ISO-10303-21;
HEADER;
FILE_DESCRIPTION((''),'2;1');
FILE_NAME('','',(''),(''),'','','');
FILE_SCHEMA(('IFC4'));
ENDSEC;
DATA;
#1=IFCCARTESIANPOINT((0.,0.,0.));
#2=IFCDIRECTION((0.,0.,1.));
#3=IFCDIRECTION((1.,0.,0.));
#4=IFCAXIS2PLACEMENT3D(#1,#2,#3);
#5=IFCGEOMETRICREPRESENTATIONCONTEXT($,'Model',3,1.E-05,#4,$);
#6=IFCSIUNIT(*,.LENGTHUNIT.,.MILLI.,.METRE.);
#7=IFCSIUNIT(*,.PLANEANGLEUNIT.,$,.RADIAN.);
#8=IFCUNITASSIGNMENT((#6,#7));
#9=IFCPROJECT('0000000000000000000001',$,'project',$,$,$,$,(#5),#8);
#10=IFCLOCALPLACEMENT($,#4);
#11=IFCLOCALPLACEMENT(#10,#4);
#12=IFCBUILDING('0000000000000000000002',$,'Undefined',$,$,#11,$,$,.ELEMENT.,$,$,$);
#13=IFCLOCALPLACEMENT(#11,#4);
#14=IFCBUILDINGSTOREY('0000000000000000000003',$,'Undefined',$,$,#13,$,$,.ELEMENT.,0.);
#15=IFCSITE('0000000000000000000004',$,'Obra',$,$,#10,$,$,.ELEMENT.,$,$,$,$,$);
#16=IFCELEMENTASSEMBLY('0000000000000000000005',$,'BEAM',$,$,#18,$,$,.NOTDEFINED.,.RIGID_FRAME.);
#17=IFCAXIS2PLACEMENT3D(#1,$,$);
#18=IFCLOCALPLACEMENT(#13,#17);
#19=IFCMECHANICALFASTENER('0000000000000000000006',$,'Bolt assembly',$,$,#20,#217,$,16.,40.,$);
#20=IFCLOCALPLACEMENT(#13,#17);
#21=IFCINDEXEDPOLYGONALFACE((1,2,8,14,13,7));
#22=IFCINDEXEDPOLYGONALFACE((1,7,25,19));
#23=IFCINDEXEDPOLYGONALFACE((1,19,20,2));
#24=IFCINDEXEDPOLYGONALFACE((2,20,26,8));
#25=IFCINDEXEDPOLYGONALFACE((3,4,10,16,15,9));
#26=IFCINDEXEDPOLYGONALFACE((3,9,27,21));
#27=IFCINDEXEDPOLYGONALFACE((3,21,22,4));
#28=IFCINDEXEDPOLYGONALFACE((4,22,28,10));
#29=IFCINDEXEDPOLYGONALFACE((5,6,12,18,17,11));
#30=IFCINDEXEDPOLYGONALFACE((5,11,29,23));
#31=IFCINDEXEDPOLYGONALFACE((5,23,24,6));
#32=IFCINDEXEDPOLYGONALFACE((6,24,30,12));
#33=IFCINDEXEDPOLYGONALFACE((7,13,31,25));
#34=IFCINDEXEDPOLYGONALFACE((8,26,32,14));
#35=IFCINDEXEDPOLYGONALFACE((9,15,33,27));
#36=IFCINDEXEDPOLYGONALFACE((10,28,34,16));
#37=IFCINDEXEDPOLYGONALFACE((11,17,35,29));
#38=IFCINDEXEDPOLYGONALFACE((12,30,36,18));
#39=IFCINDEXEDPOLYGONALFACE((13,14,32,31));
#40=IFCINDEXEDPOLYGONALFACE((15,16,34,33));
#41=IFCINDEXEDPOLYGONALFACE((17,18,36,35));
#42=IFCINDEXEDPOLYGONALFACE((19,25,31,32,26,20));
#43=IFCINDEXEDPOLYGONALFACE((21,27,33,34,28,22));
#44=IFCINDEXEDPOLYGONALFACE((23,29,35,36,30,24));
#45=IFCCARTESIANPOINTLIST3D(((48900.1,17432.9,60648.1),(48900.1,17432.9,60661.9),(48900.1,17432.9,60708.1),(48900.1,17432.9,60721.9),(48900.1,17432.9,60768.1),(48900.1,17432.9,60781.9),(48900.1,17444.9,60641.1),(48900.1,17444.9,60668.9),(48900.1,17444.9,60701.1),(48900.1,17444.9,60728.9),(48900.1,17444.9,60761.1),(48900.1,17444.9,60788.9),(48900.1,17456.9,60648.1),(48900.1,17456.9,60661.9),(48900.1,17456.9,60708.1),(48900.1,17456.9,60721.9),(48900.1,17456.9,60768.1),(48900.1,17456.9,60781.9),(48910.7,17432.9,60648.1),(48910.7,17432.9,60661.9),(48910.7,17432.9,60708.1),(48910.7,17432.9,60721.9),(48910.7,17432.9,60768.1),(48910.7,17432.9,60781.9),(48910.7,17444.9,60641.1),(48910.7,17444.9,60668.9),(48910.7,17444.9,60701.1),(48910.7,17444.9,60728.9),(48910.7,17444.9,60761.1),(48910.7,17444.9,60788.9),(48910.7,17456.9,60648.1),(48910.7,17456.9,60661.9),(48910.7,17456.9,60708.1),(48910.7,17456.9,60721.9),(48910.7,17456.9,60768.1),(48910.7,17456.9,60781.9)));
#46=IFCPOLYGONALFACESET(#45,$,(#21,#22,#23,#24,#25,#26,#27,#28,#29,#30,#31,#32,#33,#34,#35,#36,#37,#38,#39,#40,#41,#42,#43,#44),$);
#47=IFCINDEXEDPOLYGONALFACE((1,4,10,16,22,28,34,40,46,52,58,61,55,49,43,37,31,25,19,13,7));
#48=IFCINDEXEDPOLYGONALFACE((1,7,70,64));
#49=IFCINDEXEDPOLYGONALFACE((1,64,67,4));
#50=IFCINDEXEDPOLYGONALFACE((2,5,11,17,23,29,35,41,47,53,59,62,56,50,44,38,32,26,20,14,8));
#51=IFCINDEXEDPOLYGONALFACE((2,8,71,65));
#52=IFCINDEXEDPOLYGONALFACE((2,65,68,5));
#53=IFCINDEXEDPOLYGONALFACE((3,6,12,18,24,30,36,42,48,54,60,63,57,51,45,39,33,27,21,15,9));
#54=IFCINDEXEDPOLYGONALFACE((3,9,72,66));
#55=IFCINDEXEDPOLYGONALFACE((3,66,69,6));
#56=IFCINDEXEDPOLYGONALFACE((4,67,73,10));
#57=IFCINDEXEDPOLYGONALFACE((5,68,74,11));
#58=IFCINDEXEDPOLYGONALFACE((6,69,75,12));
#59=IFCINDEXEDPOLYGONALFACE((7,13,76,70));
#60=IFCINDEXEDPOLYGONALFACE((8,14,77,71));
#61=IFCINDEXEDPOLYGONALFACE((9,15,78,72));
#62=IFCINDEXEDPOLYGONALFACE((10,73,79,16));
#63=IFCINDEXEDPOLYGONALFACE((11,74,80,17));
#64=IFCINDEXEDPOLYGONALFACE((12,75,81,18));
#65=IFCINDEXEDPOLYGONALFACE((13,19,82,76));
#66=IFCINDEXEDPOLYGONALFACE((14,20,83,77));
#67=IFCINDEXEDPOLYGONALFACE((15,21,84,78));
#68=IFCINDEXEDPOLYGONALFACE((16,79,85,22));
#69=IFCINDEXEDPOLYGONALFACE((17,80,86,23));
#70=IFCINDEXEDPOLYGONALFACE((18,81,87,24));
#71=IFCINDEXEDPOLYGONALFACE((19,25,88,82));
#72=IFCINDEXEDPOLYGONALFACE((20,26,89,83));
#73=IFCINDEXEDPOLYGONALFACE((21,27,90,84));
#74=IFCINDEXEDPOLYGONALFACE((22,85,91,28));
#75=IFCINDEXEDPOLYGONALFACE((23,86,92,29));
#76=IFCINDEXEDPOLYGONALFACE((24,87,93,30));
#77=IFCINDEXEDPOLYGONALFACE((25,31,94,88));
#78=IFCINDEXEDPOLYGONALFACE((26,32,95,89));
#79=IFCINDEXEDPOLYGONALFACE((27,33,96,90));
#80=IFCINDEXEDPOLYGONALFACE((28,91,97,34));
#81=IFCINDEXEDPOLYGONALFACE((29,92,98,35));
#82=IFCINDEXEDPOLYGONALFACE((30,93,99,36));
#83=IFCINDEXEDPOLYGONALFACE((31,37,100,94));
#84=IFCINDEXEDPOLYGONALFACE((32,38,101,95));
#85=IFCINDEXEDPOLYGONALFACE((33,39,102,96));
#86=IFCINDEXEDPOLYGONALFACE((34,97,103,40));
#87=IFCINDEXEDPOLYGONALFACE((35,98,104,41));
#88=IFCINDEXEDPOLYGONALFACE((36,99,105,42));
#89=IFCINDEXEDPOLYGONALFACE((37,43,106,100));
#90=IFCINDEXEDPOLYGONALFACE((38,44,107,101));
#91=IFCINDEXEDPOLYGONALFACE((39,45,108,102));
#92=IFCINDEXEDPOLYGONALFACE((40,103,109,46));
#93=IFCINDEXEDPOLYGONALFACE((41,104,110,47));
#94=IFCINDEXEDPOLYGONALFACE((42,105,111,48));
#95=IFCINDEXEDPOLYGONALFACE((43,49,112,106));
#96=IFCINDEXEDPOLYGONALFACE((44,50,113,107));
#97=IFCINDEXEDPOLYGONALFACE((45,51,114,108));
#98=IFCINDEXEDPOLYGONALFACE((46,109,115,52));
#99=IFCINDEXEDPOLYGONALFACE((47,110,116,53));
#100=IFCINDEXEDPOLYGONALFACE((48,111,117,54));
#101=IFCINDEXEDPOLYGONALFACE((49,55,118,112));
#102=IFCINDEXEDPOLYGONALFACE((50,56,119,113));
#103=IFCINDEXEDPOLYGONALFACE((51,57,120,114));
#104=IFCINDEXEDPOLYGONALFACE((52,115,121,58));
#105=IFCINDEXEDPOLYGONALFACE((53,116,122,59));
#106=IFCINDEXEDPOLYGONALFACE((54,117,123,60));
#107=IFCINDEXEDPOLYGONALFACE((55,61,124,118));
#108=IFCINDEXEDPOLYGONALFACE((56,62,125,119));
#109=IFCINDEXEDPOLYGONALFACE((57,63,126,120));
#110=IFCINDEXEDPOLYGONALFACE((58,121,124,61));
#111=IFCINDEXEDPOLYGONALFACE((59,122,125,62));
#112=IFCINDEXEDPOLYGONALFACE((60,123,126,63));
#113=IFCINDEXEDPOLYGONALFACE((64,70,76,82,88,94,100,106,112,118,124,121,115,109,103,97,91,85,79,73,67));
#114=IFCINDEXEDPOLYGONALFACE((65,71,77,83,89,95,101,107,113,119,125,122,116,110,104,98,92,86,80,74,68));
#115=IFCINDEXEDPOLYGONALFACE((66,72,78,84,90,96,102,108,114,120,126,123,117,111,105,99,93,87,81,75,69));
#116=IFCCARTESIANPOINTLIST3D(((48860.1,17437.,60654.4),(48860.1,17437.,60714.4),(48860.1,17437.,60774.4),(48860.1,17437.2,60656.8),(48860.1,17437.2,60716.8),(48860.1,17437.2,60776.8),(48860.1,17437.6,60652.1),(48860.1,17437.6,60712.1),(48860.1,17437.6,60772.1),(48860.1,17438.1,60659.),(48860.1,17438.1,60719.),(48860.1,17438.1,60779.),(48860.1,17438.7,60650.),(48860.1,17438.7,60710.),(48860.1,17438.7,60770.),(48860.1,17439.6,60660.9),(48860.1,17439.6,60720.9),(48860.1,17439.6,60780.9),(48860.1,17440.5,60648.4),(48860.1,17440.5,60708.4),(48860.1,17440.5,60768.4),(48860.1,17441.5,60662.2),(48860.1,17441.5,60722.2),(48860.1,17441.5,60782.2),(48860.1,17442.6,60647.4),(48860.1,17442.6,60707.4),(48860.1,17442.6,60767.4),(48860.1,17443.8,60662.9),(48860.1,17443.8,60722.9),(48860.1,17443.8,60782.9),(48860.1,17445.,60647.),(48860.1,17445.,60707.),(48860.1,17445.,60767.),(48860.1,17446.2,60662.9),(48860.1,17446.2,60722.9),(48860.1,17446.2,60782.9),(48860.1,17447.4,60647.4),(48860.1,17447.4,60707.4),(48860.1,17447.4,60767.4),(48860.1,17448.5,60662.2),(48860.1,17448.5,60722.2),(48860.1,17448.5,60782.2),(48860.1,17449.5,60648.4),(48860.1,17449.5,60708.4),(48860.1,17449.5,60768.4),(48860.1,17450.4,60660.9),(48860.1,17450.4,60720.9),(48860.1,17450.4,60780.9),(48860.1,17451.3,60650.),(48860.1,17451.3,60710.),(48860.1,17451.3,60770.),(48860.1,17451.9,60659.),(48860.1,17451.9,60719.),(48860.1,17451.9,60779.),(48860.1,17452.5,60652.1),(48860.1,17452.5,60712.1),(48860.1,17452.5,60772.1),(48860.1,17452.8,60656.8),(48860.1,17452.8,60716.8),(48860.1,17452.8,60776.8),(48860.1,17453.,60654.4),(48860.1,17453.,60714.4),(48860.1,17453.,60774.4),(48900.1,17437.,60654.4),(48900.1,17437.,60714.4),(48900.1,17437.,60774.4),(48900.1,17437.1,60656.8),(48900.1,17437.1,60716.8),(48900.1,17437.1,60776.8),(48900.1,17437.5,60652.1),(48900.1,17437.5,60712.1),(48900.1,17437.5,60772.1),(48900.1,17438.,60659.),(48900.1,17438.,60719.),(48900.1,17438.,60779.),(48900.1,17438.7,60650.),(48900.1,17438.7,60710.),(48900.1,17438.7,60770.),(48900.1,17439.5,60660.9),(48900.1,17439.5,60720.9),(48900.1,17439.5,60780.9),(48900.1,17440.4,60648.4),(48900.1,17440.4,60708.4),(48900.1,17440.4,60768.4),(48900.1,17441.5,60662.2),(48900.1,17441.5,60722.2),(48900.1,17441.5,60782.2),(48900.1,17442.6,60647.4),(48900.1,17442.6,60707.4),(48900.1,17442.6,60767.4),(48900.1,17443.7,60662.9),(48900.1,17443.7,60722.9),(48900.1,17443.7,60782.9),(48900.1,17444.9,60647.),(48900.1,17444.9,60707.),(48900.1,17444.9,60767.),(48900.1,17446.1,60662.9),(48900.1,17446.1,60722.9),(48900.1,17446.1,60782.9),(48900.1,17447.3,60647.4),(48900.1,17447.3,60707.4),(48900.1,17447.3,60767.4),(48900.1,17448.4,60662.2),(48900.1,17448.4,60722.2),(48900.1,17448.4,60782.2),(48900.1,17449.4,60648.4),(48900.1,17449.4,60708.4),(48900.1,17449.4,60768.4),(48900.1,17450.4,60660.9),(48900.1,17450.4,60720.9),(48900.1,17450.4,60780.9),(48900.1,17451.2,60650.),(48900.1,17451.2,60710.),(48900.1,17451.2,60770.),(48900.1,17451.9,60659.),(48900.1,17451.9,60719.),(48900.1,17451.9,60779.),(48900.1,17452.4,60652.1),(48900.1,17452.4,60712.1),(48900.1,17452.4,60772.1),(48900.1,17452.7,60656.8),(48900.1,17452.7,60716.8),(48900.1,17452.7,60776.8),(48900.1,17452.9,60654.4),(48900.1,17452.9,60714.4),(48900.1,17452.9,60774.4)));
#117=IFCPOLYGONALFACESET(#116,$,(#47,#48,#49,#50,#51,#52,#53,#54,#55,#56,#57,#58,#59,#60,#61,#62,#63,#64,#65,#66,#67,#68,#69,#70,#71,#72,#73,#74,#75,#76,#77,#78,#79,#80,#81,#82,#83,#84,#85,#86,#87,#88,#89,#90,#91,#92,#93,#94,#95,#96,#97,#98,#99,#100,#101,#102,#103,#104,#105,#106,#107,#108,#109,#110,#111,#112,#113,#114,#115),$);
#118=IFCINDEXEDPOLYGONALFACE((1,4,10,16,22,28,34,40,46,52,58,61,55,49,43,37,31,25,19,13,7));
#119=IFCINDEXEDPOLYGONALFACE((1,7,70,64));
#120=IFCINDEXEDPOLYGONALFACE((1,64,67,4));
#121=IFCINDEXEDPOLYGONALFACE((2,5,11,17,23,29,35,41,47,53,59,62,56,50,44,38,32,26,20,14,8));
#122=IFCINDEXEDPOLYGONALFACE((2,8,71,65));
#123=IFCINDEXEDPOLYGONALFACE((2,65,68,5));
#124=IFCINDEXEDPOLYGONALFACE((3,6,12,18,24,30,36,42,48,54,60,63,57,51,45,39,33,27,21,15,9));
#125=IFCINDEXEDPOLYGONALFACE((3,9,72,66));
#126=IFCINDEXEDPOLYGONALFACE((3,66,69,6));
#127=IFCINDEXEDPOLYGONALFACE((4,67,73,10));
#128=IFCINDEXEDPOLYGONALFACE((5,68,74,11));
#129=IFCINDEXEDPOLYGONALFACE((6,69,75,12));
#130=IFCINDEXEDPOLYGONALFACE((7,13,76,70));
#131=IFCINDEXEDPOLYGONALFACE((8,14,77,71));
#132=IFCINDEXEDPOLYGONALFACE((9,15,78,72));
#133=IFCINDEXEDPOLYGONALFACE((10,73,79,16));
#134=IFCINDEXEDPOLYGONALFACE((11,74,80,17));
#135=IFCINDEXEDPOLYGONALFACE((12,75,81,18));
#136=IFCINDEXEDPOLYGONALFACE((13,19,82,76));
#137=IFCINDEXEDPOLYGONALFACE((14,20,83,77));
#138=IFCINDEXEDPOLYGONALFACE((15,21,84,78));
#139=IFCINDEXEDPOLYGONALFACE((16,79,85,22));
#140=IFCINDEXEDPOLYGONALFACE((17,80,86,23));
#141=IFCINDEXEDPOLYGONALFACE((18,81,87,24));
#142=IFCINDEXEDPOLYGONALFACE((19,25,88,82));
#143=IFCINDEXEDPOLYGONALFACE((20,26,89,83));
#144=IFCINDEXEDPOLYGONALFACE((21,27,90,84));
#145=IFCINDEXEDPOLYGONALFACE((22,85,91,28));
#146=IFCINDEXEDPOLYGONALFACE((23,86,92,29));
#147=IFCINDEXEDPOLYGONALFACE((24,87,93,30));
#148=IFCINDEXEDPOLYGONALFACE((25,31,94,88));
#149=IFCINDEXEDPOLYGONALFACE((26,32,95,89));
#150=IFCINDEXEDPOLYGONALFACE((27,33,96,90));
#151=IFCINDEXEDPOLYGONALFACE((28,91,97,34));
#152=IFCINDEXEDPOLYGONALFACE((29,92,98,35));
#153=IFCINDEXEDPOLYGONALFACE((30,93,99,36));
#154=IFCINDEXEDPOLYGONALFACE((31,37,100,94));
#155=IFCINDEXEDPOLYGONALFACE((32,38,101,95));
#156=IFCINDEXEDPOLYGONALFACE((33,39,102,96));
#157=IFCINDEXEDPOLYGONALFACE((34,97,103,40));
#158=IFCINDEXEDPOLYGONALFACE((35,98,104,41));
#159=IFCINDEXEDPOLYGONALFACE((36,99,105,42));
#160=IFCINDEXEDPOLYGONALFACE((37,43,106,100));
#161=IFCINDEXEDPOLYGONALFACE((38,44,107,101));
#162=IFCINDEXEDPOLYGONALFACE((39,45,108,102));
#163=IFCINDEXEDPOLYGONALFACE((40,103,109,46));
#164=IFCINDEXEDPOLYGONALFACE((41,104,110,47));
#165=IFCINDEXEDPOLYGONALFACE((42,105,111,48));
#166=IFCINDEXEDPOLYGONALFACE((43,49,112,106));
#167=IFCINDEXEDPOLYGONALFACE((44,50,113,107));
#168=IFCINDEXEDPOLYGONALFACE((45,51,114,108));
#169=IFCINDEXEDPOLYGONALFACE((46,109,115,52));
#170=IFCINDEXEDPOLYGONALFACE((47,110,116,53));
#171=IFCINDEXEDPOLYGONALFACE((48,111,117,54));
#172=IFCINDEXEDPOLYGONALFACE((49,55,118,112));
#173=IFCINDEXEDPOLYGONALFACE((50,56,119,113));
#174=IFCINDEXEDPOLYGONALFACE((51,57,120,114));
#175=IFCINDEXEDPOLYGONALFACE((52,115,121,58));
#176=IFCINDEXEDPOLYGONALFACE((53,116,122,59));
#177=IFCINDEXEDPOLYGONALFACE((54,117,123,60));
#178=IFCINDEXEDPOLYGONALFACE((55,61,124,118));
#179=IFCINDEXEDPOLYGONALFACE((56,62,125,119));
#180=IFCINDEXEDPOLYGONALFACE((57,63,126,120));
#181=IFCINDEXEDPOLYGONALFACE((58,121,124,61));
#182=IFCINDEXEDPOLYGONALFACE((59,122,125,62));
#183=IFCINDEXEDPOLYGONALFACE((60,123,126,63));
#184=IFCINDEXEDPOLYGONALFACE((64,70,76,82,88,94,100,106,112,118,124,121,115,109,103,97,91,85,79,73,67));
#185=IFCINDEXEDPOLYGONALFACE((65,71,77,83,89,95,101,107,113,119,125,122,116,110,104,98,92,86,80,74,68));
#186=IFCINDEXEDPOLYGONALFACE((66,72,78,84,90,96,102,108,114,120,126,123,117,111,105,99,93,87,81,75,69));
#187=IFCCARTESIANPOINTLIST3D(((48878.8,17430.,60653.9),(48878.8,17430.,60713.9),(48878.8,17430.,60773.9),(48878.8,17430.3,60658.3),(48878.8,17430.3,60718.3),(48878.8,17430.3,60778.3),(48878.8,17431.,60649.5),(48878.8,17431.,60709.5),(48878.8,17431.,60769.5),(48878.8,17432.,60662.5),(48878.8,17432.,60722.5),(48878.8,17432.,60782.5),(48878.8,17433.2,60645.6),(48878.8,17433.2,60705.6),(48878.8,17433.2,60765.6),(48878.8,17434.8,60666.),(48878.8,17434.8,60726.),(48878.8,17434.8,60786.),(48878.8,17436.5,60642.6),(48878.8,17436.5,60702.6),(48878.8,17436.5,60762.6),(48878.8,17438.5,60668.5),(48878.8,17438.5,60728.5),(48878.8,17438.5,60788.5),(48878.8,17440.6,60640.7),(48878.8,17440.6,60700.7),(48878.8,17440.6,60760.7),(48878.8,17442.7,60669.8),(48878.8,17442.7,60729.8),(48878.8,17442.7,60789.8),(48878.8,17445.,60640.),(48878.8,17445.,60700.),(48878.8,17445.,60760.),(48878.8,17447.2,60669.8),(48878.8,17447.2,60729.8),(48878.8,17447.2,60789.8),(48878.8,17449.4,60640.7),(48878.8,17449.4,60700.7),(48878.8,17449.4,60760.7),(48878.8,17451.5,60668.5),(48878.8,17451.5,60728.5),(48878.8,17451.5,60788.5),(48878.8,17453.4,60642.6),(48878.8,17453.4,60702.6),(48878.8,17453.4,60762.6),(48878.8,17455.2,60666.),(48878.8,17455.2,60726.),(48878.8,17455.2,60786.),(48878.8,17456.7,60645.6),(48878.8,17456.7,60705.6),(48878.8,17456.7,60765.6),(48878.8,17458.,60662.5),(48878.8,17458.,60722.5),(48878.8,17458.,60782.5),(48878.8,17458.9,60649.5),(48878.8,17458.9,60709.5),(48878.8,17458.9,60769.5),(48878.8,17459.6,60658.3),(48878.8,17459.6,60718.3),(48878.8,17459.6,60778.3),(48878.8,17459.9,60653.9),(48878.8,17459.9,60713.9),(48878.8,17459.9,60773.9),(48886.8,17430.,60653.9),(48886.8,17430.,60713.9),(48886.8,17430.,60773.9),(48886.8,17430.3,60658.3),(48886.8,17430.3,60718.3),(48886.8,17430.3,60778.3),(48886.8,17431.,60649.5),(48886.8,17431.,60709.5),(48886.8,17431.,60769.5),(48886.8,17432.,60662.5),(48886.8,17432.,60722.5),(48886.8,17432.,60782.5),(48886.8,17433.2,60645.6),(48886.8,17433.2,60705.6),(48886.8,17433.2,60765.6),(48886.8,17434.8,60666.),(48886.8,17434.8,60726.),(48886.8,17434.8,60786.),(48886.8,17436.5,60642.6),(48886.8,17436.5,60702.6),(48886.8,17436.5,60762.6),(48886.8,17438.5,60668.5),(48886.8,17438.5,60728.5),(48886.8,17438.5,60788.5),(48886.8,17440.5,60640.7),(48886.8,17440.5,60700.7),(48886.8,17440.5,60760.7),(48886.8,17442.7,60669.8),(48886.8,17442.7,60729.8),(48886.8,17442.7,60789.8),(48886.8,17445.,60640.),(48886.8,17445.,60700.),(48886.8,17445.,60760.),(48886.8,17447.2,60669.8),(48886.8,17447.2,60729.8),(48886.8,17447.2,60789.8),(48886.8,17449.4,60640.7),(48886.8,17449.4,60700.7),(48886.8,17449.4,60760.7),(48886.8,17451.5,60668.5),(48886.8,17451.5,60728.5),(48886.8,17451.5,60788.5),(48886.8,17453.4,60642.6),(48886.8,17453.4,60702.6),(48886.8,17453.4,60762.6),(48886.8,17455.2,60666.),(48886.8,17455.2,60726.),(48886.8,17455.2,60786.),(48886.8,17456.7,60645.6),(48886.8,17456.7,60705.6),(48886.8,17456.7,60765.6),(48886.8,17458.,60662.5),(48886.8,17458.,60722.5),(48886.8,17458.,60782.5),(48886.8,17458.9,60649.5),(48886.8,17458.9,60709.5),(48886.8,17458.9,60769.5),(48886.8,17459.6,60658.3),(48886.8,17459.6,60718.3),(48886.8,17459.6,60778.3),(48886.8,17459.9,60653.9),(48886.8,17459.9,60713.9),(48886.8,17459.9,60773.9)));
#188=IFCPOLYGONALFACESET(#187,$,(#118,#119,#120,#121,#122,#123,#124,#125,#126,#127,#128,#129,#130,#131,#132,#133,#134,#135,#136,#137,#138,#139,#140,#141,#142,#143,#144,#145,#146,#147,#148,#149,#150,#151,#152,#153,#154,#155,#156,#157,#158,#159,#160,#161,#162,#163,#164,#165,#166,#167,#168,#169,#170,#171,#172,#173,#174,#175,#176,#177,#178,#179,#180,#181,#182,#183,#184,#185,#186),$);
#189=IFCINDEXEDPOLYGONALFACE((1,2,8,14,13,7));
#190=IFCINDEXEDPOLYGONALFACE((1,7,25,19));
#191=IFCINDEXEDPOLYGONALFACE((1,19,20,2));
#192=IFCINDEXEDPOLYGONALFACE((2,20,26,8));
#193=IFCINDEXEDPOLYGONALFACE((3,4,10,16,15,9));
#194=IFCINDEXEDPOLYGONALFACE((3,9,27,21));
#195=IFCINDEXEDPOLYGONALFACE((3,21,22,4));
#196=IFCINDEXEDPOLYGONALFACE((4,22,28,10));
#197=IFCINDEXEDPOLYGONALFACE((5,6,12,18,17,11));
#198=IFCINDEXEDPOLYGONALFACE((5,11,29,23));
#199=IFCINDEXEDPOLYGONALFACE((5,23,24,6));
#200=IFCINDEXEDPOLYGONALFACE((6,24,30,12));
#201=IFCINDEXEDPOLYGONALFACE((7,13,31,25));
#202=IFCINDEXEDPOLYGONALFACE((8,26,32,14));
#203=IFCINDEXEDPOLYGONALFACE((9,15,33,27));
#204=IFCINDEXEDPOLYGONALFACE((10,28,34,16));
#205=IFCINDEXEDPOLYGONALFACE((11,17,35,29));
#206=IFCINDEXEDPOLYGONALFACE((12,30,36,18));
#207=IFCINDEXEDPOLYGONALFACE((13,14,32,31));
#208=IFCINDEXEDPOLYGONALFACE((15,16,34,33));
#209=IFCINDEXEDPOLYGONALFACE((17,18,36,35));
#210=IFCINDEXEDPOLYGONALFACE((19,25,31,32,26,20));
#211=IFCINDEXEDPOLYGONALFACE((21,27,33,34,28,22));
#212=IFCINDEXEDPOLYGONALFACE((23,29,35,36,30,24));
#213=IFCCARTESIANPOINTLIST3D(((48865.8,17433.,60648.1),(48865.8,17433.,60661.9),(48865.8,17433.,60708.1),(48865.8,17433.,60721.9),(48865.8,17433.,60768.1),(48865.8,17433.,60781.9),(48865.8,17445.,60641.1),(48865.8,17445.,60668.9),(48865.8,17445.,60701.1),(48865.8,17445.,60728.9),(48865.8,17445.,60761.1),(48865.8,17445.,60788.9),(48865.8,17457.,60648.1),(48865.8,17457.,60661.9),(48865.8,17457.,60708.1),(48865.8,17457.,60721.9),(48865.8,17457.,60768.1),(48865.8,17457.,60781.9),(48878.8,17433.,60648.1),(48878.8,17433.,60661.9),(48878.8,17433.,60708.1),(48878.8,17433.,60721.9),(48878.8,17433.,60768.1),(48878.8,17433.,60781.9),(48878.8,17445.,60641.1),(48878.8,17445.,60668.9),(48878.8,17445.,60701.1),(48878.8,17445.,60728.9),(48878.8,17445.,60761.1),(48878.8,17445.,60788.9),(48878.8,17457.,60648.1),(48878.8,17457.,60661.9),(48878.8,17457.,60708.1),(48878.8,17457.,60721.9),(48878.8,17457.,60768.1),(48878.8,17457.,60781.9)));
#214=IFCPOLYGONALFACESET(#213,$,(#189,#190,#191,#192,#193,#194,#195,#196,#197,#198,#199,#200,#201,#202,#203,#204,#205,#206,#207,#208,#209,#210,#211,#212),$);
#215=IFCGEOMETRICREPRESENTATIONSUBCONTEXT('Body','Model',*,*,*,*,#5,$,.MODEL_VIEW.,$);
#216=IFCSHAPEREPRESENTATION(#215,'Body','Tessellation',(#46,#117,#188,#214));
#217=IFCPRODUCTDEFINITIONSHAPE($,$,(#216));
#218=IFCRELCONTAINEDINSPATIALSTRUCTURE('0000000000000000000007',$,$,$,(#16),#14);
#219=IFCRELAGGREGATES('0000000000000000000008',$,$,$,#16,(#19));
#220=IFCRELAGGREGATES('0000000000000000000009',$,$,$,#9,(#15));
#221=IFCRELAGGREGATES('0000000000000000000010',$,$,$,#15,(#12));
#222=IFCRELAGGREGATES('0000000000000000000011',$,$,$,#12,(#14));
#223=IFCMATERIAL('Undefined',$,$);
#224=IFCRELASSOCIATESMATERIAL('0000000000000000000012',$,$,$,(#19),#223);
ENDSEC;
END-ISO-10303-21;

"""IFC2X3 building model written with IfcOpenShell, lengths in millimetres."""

from ifc_helpers import new_model, si_unit, frame, origin_with_axes, origin_2d_with_axis, place, context, subcontext, project, spatial, polyline, circle, outline, extrude, source, transform, mapped, material, element, aggregate, save


model = new_model("IFC2X3")

# Units and contexts
model_context = context("Model", 3, precision=1e-05, world=origin_with_axes())
body_context = subcontext(model_context, "Body", "Model", "MODEL_VIEW")
ifc_project = project(units=[si_unit("LENGTHUNIT", "METRE", prefix="MILLI"), si_unit("PLANEANGLEUNIT", "RADIAN")], contexts=[model_context])

# Site, building, storey
site_placement = place(None, origin_with_axes())
site = spatial("IfcSite", under=ifc_project, at=site_placement, Name="Obra", CompositionType="ELEMENT")
building_placement = place(site_placement, origin_with_axes())
building = spatial("IfcBuilding", under=site, at=building_placement, Name="Undefined", CompositionType="ELEMENT")
storey_placement = place(building_placement, origin_with_axes())
storey = spatial("IfcBuildingStorey", under=building, at=storey_placement, Name="Undefined", CompositionType="ELEMENT", Elevation=0.0)

# Element assembly, mechanical fastener
ifc_material_1 = material(Name="Undefined")
assembly_1_placement = place(storey_placement, origin_with_axes())
assembly_1 = element("IfcElementAssembly", 1, at=assembly_1_placement, inside=storey, Name="BEAM", AssemblyPlace="NOTDEFINED", PredefinedType="RIGID_FRAME")
shared_shape_1 = source(origin_with_axes(), body_context, "Body", "SweptSolid", [
    extrude(outline(polyline([(13.9, 0.0), (6.9, 12.0), (-6.9, 12.0), (-13.9, 0.0), (-6.9, -12.0), (6.9, -12.0), (13.9, 0.0)])), frame((0.0, -19.7, 0.0), z_axis=(0.0, 1.0, 0.0), x_axis=(1.0, 0.0, 0.0)), (0.0, 0.0, 1.0), 10.6),
    extrude(circle(Radius=8.0, at=origin_2d_with_axis()), frame((0.0, -9.1, 0.0), z_axis=(0.0, 1.0, 0.0), x_axis=(1.0, 0.0, 0.0)), (0.0, 0.0, 1.0), 40.0),
    extrude(circle(Radius=15.0, at=origin_2d_with_axis()), frame((0.0, 4.2, 0.0), z_axis=(0.0, 1.0, 0.0), x_axis=(1.0, 0.0, 0.0)), (0.0, 0.0, 1.0), 8.0),
    extrude(outline(polyline([(13.9, 0.0), (6.9, 12.0), (-6.9, 12.0), (-13.9, 0.0), (-6.9, -12.0), (6.9, -12.0), (13.9, 0.0)])), frame((0.0, 12.2, 0.0), z_axis=(0.0, 1.0, 0.0), x_axis=(1.0, 0.0, 0.0)), (0.0, 0.0, 1.0), 13.0),
])
mechanical_fastener_1_placement = place(assembly_1_placement, frame((48890.9, 17395.0, 60835.0), z_axis=(0.001649, 0.999999, 0.0), x_axis=(0.0, 0.0, -1.0)))
mechanical_fastener_1 = element("IfcMechanicalFastener", 2, at=mechanical_fastener_1_placement, material=ifc_material_1, Name="Bolt assembly", NominalDiameter=16.0, NominalLength=40.0, context=body_context, shape_type="MappedRepresentation", body=[
    mapped(shared_shape_1, transform((60.0, 0.0, 50.0))),
    mapped(shared_shape_1, transform((120.0, 0.0, 50.0))),
    mapped(shared_shape_1, transform((180.0, 0.0, 50.0))),
])

aggregate(assembly_1, [mechanical_fastener_1])

save(model, "model.ifc")
